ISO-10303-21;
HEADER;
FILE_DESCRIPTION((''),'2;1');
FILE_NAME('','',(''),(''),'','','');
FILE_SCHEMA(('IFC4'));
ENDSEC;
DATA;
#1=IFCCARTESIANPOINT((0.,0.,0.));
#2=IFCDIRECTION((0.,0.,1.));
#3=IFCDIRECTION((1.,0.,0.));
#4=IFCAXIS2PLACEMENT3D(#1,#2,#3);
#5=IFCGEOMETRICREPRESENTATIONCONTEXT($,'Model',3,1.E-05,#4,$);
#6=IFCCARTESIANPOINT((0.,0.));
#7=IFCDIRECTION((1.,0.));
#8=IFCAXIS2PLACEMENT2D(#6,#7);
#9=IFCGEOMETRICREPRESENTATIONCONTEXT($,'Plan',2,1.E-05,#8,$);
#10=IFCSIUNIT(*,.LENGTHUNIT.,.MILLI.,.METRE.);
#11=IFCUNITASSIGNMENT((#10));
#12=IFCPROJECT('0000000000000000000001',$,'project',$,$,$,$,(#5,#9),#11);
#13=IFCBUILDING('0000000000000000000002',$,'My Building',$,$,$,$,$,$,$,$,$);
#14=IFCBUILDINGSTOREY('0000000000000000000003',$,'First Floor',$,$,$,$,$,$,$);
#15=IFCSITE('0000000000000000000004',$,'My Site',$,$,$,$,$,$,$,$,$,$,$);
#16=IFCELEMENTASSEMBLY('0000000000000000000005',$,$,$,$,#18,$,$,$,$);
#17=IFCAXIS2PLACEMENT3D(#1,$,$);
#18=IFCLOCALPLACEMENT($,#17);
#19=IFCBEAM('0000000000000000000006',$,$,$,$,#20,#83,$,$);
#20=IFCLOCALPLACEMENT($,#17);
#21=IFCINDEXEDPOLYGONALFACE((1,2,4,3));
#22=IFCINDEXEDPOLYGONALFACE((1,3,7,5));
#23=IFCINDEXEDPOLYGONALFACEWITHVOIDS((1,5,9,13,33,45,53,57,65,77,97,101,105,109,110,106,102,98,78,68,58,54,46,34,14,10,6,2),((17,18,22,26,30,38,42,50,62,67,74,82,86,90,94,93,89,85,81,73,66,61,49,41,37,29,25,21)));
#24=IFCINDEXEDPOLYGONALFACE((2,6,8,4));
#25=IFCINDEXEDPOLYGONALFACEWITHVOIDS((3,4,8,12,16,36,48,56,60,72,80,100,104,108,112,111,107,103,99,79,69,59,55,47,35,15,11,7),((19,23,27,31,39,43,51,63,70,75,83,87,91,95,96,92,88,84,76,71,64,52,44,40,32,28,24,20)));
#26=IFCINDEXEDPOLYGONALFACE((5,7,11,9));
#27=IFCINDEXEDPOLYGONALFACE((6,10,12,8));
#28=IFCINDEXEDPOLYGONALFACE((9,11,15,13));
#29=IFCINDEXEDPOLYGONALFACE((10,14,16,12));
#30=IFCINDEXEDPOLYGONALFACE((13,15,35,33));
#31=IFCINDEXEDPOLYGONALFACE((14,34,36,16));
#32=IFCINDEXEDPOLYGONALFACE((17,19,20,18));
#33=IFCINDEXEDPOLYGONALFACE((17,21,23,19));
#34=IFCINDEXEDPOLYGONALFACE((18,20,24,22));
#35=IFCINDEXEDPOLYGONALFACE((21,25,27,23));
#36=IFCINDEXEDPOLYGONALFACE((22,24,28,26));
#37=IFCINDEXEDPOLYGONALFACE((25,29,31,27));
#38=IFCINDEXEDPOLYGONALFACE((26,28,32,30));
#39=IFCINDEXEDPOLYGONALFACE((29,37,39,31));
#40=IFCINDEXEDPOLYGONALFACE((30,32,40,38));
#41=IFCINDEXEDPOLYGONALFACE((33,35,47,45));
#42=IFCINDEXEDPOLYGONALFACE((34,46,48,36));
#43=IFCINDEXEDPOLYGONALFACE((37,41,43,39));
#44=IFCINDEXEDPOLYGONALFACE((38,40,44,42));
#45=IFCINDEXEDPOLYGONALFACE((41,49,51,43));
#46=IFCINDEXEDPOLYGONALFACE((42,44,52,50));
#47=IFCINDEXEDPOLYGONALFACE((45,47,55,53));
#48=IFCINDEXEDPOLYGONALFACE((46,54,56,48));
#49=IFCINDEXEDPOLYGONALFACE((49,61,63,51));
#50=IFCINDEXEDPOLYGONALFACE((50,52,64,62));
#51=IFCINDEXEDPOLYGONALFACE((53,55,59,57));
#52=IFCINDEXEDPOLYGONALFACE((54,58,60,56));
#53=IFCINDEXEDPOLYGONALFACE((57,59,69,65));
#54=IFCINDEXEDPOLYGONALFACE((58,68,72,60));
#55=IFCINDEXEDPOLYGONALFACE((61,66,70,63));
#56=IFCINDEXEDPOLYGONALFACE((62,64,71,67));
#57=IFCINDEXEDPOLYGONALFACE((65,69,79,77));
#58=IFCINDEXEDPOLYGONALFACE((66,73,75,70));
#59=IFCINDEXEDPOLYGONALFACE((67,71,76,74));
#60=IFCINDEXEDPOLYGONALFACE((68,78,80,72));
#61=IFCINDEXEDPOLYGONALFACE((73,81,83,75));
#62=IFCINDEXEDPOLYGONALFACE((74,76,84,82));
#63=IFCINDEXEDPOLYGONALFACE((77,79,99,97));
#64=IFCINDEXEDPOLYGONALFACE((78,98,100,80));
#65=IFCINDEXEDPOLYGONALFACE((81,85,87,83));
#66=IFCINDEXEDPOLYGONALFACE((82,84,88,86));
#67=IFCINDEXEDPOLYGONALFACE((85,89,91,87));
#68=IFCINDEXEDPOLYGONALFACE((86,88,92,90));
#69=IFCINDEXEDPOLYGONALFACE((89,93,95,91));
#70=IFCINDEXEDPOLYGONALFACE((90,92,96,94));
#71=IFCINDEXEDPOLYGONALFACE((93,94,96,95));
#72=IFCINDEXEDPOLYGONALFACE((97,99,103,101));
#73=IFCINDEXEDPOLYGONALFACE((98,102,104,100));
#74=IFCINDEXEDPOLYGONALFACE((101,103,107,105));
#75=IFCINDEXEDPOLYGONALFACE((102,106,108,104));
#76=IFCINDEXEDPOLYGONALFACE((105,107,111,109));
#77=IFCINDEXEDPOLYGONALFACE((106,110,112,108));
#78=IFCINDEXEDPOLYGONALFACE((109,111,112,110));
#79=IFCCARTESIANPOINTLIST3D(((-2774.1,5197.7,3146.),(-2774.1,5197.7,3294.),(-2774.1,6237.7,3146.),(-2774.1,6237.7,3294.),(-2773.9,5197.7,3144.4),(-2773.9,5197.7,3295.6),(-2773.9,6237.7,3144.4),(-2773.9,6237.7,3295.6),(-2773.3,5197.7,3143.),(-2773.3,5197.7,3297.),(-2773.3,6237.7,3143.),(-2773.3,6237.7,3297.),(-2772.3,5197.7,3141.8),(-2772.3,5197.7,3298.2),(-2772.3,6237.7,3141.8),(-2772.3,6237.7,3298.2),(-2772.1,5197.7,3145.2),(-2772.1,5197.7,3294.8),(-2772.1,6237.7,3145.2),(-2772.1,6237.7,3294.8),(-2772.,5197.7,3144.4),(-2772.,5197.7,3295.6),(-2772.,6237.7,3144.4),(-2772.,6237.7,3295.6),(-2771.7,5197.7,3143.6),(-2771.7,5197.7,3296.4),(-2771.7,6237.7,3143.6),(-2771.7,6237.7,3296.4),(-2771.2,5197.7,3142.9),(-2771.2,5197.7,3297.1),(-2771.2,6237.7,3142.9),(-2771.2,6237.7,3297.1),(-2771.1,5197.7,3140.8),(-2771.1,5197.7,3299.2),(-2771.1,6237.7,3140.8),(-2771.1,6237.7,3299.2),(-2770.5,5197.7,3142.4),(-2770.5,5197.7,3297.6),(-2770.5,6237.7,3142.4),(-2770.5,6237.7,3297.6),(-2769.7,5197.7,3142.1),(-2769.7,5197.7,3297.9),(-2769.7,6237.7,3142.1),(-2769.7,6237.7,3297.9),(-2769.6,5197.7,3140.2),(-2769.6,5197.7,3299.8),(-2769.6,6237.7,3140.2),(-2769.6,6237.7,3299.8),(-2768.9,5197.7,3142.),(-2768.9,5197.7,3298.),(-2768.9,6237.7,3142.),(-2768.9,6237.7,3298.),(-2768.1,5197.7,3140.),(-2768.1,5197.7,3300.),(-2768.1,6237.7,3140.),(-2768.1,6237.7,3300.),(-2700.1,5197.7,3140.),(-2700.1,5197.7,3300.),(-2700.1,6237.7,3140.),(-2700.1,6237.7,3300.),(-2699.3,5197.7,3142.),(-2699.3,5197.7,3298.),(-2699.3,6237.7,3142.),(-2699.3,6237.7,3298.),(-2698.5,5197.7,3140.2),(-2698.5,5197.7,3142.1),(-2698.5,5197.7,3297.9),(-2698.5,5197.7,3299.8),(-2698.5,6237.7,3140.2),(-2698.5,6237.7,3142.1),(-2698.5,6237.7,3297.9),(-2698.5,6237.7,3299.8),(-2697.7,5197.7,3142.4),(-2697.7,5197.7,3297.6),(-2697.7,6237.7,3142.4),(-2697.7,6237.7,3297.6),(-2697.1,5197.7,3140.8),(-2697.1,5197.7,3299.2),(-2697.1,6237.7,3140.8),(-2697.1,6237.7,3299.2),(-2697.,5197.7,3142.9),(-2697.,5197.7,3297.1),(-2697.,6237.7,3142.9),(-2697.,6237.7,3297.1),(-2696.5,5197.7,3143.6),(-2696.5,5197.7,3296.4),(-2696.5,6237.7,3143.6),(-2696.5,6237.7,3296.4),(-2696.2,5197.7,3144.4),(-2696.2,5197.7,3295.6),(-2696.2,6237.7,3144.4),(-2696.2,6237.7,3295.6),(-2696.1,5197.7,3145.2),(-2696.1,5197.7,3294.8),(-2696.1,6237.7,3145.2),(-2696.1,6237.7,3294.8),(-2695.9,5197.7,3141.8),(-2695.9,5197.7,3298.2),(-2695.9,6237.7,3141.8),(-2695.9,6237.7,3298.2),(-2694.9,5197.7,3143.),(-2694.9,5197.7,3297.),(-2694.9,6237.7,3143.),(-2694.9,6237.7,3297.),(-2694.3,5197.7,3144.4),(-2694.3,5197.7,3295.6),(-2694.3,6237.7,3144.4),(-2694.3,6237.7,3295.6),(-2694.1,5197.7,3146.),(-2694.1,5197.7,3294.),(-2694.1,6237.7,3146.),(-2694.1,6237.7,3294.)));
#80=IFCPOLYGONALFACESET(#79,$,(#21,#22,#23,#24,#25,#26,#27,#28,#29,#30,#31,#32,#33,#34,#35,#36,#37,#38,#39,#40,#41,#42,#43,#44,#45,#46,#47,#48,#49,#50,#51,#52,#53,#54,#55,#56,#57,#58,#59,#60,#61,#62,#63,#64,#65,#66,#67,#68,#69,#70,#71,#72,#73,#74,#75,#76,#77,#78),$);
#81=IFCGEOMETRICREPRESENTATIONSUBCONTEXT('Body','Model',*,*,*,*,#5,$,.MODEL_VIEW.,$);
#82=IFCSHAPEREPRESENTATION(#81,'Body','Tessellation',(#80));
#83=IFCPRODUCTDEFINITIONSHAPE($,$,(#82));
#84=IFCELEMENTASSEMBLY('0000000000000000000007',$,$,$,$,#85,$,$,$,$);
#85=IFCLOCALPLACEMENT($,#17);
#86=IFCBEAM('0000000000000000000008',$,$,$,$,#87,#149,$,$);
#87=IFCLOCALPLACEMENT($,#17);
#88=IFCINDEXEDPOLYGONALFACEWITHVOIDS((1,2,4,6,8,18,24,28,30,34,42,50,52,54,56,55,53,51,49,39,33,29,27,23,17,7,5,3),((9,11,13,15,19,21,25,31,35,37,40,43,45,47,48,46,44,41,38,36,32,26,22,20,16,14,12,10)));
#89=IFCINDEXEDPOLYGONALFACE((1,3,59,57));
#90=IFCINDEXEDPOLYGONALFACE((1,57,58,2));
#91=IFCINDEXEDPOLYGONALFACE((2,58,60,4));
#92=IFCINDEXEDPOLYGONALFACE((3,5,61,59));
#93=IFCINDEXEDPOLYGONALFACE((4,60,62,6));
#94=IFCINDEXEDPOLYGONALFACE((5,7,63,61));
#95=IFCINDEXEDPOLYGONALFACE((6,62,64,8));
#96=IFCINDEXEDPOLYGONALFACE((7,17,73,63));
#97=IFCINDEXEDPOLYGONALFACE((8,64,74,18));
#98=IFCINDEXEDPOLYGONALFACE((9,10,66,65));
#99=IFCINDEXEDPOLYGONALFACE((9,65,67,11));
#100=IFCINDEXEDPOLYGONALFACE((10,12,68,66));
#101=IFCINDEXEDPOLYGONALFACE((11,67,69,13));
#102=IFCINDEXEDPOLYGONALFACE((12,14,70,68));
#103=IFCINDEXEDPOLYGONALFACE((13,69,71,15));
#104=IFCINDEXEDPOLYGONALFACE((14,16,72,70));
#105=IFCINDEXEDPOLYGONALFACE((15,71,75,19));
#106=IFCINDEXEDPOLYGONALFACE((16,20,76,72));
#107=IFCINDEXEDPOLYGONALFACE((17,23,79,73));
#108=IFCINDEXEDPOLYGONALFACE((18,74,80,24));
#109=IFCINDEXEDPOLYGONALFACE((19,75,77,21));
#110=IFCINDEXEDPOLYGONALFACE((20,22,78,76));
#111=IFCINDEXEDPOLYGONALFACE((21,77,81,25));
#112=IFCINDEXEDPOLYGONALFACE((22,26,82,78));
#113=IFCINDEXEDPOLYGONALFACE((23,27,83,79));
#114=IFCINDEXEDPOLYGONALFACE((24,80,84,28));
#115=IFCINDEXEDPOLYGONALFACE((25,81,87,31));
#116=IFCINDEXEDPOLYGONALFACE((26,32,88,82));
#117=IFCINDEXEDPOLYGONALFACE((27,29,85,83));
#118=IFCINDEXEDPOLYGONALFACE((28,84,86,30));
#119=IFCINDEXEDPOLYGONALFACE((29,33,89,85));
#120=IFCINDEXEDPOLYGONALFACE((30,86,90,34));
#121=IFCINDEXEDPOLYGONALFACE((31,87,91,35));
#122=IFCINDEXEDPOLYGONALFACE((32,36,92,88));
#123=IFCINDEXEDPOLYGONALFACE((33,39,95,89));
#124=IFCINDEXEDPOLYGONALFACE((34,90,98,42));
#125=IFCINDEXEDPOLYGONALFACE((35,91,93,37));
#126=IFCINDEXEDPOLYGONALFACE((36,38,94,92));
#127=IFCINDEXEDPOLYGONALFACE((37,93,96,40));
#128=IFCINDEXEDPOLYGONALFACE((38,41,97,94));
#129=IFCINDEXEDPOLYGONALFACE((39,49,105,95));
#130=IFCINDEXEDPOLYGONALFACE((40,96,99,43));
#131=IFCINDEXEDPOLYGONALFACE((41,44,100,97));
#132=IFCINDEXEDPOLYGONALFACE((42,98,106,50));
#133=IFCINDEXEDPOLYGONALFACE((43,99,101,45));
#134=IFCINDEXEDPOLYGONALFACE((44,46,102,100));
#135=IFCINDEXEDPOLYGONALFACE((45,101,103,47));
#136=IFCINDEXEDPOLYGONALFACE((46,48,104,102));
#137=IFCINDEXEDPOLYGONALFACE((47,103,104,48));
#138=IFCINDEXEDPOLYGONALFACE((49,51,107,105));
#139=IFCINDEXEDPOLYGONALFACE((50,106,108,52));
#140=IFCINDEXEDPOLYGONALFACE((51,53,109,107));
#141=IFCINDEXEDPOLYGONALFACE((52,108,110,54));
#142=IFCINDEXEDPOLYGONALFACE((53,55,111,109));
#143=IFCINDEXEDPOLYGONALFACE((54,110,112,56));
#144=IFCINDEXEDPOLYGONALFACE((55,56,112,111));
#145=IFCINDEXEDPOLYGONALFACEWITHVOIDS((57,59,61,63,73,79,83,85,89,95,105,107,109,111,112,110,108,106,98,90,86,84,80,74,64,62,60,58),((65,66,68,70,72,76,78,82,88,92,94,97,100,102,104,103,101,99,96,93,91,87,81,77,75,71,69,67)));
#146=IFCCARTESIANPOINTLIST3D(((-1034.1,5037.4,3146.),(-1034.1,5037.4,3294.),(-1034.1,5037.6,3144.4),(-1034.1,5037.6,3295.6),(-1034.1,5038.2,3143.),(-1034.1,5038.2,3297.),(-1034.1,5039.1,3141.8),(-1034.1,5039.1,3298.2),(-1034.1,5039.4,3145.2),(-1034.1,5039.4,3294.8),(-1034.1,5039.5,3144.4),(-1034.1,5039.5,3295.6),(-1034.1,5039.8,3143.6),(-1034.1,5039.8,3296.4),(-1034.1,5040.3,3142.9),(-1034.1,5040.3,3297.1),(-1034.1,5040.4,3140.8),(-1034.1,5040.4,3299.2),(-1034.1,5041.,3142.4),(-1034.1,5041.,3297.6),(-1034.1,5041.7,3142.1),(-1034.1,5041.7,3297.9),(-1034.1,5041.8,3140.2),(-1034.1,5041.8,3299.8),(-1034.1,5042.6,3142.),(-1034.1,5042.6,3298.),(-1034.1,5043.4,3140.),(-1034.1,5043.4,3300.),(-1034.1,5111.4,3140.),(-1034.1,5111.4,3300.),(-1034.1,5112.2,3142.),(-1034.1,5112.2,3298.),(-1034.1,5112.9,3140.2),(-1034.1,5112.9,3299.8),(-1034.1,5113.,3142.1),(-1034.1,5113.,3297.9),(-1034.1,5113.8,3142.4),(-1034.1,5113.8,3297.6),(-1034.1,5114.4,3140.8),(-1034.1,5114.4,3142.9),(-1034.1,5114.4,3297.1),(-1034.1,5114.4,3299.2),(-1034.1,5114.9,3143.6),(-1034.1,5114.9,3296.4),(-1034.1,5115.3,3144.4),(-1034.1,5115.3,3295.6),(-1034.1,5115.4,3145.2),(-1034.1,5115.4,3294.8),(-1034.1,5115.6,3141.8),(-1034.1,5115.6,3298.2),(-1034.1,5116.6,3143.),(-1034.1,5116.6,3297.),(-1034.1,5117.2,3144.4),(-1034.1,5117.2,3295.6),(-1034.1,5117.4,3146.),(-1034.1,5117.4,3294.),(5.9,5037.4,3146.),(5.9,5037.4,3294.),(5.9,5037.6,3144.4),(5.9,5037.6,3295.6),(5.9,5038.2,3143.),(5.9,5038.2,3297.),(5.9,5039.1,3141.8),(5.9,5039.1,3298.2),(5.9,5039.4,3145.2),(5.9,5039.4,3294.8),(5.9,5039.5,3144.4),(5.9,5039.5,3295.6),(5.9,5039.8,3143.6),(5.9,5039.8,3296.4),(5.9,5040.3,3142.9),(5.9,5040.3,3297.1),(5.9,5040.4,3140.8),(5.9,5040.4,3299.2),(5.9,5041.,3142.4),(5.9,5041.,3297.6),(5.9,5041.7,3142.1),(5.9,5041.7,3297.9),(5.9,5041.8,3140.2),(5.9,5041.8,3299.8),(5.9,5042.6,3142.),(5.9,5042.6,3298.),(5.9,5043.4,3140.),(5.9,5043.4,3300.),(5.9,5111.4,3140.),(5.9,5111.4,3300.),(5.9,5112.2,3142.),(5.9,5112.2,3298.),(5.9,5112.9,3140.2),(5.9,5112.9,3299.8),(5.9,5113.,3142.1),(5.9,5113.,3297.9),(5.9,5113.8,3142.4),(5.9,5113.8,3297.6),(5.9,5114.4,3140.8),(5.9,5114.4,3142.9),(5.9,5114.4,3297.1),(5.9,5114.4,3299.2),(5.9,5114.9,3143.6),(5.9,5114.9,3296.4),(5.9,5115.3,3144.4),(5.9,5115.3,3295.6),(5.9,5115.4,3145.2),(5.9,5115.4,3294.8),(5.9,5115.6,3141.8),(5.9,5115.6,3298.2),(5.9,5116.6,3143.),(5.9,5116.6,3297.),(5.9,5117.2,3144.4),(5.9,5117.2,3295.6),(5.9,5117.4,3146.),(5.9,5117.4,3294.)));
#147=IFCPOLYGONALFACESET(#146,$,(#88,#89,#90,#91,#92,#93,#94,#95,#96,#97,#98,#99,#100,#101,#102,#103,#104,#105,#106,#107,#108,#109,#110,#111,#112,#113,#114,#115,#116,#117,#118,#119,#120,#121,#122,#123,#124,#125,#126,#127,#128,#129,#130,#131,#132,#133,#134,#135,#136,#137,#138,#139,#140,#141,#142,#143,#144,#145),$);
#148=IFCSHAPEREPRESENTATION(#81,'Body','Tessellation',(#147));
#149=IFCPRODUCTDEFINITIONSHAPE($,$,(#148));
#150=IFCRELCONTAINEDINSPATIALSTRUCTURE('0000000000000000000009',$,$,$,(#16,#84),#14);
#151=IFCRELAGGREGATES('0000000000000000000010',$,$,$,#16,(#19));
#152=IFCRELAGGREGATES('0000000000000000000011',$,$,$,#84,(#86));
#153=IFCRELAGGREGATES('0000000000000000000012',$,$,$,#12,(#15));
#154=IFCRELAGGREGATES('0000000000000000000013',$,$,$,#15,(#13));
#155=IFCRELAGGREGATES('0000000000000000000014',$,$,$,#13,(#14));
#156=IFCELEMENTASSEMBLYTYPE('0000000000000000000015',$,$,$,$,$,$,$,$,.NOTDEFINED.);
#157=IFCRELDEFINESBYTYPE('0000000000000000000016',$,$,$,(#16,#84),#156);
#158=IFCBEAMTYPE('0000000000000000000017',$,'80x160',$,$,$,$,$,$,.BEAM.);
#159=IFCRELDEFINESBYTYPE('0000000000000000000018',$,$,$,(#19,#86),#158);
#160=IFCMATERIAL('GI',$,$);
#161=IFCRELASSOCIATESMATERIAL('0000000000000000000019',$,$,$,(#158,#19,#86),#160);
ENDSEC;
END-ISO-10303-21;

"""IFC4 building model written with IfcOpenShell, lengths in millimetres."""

from ifc_helpers import new_model, si_unit, frame, origin_with_axes, origin_2d_with_axis, place, context, subcontext, project, spatial, hollow_rectangle, extrude, material, material_profile, profile_set, profile_usage, type_object, element, aggregate, save


model = new_model("IFC4")

# Units and contexts
model_context = context("Model", 3, precision=1e-05, world=origin_with_axes())
plan_context = context("Plan", 2, precision=1e-05, world=origin_2d_with_axis())
body_context = subcontext(model_context, "Body", "Model", "MODEL_VIEW")
ifc_project = project(units=[si_unit("LENGTHUNIT", "METRE", prefix="MILLI")], contexts=[model_context, plan_context])

# Site, building, storey
site = spatial("IfcSite", under=ifc_project, Name="My Site")
building = spatial("IfcBuilding", under=site, Name="My Building")
storey = spatial("IfcBuildingStorey", under=building, Name="First Floor")

# Element assemblies, beams
element_assembly_type = type_object("IfcElementAssemblyType", PredefinedType="NOTDEFINED")
ifc_material = material(Name="GI")
ifc_material_profile = material_profile(ifc_material, hollow_rectangle(XDim=80.0, YDim=160.0, WallThickness=2.0, InnerFilletRadius=3.2, OuterFilletRadius=6.0))
ifc_profile_set = profile_set([ifc_material_profile], Name="80x160 GI Rectangular Hollow")
beam_type = type_object("IfcBeamType", Name="80x160", PredefinedType="BEAM", material=ifc_profile_set)
assembly_1_placement = place(None, frame((-2734.1, 5117.7, 3220.0), z_axis=(0.0, 1.0, 0.0), x_axis=(1.0, 0.0, 0.0)))
assembly_1 = element("IfcElementAssembly", 1, at=assembly_1_placement, inside=storey, type_object=element_assembly_type)
ifc_profile_usage_1 = profile_usage(ifc_profile_set)
beam_1_placement = place(assembly_1_placement, frame((0.0, 0.0, 80.0), z_axis=(0.0, 0.0, 1.0), x_axis=(1.0, 0.0, 0.0)))
beam_1 = element("IfcBeam", 2, at=beam_1_placement, type_object=beam_type, material=ifc_profile_usage_1, context=body_context, shape_type="SweptSolid", body=[
    extrude(hollow_rectangle(XDim=80.0, YDim=160.0, WallThickness=2.0, InnerFilletRadius=3.2, OuterFilletRadius=6.0), origin_with_axes(), (0.0, 0.0, 1.0), 1040.0),
])
aggregate(assembly_1, [beam_1])
assembly_2_placement = place(None, frame((-1114.1, 5077.4, 3220.0), z_axis=(1.0, 0.0, 0.0), x_axis=(0.0, 1.0, 0.0)))
assembly_2 = element("IfcElementAssembly", 3, at=assembly_2_placement, inside=storey, type_object=element_assembly_type)
ifc_profile_usage_2 = profile_usage(ifc_profile_set)
beam_2_placement = place(assembly_2_placement, frame((0.0, 0.0, 80.0), z_axis=(0.0, 0.0, 1.0), x_axis=(1.0, 0.0, 0.0)))
beam_2 = element("IfcBeam", 4, at=beam_2_placement, type_object=beam_type, material=ifc_profile_usage_2, context=body_context, shape_type="SweptSolid", body=[
    extrude(hollow_rectangle(XDim=80.0, YDim=160.0, WallThickness=2.0, InnerFilletRadius=3.2, OuterFilletRadius=6.0), origin_with_axes(), (0.0, 0.0, 1.0), 1040.0),
])
aggregate(assembly_2, [beam_2])

save(model, "model.ifc")
